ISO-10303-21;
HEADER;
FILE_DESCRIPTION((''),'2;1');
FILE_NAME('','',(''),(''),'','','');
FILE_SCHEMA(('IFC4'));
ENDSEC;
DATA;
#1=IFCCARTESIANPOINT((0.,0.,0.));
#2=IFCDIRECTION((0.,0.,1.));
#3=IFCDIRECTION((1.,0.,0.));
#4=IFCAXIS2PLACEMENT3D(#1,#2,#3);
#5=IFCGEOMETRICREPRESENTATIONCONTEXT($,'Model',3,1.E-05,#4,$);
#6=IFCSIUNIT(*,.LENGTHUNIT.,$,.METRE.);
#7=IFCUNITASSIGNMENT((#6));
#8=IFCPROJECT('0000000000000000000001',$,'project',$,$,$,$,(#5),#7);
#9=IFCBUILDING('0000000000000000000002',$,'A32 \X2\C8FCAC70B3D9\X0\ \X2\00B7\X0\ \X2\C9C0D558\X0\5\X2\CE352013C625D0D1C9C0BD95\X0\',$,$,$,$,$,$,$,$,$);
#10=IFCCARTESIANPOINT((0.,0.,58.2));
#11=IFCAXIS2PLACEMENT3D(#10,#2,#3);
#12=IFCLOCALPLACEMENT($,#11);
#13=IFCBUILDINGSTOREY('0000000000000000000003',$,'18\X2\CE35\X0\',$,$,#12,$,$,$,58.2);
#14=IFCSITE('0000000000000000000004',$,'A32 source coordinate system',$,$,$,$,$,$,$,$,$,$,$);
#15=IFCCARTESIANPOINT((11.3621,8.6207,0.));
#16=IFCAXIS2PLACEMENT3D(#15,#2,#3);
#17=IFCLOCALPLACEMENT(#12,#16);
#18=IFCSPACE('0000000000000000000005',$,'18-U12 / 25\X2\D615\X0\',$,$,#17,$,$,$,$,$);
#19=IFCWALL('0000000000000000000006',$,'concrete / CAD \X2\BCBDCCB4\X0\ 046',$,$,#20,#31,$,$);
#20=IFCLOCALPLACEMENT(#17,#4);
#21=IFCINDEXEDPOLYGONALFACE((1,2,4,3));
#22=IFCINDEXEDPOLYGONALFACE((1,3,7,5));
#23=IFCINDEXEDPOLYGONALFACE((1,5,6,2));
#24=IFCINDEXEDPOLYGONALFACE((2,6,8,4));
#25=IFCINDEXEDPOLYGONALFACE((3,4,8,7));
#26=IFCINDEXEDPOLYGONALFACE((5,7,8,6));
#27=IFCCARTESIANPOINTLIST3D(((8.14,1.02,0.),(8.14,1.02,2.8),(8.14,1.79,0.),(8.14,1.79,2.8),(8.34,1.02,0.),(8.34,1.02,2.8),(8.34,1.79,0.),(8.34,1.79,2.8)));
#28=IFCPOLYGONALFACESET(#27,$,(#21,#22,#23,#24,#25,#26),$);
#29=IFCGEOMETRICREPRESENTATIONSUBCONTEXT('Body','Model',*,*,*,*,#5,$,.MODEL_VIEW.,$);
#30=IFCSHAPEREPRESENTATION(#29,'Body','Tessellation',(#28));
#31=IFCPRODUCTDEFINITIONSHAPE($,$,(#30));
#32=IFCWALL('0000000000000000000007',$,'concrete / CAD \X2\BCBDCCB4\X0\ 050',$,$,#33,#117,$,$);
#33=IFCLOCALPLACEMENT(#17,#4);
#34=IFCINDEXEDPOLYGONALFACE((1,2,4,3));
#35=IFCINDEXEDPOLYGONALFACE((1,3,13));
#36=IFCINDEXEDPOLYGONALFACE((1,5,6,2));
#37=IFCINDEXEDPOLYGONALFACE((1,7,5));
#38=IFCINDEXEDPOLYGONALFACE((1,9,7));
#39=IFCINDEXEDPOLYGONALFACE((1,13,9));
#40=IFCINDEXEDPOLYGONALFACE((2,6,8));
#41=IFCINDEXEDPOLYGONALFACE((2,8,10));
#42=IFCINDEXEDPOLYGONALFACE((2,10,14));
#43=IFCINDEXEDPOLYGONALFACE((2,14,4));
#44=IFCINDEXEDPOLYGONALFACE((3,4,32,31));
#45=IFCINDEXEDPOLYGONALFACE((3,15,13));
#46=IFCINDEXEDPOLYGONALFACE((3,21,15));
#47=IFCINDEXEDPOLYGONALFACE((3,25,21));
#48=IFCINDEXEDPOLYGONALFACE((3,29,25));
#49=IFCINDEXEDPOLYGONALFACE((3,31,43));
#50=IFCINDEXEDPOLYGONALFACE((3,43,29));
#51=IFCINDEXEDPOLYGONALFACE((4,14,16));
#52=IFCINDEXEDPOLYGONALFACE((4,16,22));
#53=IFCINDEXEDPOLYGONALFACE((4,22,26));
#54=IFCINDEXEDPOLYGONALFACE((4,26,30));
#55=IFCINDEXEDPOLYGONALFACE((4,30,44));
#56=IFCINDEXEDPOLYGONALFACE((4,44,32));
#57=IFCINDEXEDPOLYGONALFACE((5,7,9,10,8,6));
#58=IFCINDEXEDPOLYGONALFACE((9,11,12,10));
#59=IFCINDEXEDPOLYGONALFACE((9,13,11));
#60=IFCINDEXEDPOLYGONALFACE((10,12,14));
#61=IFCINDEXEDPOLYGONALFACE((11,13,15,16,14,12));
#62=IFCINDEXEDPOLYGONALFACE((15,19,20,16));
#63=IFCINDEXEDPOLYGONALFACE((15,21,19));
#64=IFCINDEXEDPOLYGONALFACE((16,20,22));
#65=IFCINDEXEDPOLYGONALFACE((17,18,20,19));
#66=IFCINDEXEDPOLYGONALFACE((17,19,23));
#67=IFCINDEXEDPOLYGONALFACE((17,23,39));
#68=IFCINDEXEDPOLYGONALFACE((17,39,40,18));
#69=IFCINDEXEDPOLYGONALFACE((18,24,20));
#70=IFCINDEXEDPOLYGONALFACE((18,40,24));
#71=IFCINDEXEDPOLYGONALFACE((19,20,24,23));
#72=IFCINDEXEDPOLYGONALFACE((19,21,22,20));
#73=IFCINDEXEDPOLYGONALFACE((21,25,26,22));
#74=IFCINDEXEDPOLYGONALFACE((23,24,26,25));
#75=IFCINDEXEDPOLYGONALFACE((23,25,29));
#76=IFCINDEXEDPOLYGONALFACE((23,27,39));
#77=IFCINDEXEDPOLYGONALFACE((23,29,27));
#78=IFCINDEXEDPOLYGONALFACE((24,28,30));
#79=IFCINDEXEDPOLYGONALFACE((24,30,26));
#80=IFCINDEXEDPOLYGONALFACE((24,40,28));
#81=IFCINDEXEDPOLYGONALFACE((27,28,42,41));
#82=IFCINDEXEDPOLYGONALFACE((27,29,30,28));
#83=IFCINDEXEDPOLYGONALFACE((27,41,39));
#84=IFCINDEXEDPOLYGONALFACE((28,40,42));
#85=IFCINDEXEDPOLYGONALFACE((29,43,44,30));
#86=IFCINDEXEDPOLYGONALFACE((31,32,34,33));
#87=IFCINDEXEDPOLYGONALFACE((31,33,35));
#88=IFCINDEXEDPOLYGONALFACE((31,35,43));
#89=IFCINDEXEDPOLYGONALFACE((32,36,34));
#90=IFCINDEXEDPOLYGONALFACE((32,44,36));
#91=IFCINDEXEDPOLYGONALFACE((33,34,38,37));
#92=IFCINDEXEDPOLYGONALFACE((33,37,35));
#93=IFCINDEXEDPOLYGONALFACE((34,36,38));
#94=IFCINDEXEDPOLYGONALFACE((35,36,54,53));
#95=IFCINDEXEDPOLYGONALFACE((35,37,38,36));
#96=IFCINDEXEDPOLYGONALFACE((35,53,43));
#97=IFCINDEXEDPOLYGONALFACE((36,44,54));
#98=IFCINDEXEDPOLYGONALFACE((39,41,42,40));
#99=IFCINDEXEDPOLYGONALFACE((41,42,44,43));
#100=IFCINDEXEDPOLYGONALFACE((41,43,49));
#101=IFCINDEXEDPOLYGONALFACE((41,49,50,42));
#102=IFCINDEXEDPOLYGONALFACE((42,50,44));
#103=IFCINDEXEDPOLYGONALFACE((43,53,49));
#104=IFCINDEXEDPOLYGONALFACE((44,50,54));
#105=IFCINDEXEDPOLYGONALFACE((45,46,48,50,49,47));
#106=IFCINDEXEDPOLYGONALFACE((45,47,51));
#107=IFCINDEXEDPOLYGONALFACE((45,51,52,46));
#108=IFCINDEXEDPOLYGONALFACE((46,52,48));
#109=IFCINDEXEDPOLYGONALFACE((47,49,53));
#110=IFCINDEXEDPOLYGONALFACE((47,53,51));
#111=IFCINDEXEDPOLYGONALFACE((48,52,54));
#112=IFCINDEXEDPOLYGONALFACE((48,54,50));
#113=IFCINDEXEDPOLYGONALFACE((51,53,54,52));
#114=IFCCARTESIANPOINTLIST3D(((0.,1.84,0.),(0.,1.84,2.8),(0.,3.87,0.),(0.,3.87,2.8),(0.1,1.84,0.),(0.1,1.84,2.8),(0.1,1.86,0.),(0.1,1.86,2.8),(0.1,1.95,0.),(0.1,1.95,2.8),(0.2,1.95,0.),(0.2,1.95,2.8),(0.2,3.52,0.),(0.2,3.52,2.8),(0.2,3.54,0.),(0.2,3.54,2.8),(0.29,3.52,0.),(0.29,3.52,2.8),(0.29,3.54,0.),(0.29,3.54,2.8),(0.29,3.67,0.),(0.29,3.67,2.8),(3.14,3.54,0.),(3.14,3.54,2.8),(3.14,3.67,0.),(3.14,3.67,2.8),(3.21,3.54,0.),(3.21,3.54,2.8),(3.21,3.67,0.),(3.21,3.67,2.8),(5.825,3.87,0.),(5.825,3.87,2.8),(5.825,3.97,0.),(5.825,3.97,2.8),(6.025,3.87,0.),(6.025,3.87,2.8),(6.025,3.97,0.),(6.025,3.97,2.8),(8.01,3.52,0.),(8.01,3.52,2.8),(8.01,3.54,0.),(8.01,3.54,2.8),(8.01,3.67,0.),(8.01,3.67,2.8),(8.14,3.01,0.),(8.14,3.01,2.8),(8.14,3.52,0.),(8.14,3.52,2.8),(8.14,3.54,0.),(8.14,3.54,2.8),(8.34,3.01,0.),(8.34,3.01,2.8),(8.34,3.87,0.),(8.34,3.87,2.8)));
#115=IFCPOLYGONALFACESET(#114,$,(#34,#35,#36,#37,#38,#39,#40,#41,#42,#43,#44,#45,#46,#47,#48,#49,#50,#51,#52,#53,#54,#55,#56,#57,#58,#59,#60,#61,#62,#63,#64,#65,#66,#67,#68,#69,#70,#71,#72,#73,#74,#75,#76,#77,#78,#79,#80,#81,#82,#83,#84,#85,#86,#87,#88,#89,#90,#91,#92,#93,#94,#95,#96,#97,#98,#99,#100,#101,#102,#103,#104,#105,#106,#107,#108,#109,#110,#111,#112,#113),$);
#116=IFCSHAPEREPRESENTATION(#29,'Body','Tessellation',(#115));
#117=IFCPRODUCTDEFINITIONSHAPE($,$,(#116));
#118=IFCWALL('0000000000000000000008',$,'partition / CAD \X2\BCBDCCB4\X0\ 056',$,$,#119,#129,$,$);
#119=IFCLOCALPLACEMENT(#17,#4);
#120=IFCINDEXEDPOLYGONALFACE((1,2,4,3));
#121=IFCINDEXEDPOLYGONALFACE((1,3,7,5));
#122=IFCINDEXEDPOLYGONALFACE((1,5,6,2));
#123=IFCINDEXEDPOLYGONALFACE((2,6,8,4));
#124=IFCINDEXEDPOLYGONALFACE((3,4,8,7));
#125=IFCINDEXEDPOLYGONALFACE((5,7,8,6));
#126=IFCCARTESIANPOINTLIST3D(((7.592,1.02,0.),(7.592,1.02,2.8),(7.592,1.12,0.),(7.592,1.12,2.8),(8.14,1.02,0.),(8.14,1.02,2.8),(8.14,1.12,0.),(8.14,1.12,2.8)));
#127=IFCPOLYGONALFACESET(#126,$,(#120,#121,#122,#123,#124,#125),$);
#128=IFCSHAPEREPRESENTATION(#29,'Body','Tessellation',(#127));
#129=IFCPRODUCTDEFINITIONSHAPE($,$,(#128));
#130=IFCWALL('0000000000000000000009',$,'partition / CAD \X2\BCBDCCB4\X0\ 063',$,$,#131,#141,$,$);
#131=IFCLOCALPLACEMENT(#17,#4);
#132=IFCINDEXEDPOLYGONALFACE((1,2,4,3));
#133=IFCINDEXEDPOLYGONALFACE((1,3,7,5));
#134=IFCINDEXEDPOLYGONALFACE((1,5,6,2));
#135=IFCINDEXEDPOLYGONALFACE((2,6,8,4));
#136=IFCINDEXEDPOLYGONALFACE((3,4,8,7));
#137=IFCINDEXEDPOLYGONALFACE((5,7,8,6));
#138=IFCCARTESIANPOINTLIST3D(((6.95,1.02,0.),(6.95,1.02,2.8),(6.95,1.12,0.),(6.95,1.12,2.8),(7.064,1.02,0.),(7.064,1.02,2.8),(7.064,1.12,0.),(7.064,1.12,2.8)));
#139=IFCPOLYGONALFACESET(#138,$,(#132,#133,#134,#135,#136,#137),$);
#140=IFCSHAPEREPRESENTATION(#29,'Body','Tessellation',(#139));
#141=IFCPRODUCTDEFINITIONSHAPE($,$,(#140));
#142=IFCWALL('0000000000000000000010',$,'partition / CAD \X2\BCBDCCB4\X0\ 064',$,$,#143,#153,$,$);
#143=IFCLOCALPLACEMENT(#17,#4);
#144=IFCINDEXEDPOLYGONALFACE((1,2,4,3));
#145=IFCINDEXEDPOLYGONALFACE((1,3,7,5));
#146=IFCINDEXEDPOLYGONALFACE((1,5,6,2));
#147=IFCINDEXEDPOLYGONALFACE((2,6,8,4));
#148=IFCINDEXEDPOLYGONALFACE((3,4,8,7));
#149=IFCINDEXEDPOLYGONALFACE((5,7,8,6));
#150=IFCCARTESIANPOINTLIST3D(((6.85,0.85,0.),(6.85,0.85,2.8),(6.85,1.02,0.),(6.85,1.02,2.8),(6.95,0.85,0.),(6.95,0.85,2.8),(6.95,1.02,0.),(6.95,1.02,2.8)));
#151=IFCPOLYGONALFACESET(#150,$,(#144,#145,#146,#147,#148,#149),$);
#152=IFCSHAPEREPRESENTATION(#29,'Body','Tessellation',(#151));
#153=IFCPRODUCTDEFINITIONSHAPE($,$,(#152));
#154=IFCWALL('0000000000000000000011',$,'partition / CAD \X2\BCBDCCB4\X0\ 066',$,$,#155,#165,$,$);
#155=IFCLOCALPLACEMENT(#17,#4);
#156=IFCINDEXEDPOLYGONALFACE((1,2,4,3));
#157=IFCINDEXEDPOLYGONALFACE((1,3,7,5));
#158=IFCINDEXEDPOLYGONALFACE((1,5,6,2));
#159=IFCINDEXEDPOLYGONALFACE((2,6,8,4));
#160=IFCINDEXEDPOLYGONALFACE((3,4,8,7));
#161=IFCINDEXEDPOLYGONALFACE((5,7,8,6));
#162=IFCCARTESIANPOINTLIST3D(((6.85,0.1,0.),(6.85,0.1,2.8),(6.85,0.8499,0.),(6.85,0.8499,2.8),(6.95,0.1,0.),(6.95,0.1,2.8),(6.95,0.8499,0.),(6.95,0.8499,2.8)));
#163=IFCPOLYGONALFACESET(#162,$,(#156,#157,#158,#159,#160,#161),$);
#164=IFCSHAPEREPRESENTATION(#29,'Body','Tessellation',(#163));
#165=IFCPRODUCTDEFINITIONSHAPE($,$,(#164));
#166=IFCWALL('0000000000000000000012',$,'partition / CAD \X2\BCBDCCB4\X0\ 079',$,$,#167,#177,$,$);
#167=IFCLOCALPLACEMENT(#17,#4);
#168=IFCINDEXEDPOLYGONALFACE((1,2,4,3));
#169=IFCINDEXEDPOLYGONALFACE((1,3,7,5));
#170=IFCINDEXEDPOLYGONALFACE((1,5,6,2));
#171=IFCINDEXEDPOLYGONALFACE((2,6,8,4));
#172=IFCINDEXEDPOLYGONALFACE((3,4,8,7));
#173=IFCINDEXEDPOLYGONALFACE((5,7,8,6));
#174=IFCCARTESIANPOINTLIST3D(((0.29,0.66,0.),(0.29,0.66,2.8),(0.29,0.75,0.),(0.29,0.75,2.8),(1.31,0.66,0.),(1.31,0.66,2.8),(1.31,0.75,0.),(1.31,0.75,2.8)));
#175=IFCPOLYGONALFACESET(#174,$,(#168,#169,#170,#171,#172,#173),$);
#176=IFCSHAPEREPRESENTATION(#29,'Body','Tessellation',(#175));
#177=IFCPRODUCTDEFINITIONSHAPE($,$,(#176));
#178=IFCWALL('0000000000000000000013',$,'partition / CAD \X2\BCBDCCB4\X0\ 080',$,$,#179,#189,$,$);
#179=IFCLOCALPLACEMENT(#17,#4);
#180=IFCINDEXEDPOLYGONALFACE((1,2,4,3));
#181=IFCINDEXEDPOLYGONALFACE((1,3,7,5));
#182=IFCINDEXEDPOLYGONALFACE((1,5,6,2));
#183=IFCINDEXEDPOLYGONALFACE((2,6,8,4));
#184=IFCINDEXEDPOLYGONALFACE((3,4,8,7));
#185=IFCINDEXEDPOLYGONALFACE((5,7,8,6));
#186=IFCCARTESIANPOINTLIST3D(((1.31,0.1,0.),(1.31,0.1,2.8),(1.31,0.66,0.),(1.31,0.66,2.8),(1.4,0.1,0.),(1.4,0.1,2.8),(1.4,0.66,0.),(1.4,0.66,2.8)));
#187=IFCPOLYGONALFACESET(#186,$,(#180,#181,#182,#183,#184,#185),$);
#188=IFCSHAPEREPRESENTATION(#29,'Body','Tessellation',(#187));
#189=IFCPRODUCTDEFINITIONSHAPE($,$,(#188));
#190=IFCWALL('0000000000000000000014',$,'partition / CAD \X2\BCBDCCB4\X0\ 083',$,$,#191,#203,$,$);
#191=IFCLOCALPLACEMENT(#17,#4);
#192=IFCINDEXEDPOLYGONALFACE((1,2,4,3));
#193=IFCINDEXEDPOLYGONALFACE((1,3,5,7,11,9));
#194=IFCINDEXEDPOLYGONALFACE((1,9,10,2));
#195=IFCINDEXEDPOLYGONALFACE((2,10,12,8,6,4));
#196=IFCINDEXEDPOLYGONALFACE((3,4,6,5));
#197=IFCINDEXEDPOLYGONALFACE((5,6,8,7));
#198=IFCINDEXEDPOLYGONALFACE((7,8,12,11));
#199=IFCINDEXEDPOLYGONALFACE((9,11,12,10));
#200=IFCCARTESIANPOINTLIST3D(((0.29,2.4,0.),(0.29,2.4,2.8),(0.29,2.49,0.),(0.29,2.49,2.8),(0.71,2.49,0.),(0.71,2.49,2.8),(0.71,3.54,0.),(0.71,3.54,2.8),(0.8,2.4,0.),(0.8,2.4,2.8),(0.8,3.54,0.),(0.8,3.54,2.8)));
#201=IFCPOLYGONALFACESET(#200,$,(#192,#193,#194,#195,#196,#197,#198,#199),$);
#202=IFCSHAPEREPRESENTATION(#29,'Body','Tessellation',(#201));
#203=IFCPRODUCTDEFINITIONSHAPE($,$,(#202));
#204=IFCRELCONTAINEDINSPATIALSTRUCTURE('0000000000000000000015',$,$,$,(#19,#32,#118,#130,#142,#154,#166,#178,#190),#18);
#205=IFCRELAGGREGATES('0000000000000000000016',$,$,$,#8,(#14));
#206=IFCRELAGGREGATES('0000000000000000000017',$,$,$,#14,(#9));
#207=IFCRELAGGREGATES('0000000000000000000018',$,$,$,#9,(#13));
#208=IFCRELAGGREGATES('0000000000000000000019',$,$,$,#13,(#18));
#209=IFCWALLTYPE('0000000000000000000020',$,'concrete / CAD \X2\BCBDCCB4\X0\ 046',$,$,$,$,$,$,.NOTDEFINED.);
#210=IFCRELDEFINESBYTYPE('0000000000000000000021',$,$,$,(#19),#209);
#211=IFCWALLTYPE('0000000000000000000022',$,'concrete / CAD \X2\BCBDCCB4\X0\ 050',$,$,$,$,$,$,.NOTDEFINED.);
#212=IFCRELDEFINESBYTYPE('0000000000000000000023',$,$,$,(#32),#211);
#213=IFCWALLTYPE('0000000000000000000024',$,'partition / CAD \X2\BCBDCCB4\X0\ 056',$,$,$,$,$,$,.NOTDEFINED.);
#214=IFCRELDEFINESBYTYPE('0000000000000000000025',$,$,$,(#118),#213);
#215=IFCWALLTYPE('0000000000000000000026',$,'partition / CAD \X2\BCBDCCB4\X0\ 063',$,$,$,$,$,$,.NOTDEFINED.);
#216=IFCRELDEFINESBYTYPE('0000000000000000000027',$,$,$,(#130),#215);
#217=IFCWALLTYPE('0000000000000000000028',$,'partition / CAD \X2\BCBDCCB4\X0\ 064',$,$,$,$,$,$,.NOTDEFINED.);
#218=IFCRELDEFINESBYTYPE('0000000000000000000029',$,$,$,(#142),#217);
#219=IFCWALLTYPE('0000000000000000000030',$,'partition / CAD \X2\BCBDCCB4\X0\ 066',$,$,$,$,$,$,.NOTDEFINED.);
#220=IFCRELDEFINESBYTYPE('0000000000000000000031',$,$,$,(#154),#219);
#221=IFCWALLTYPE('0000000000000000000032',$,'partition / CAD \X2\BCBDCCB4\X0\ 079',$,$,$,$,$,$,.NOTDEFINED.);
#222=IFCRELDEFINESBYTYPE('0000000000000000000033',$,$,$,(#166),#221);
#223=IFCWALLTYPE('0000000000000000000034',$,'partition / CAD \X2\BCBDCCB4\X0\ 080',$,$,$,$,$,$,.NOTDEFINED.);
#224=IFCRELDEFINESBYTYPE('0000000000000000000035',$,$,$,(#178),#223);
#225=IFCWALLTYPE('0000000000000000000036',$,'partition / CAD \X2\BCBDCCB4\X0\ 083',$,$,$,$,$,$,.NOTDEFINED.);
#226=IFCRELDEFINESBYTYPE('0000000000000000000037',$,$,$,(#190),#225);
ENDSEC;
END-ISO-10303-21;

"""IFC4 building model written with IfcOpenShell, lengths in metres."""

from ifc_helpers import new_model, si_unit, frame, origin, origin_with_axes, place, context, subcontext, project, spatial, polyline, outline, extrude, source, transform, mapped, type_object, type_shapes, element, save


model = new_model("IFC4")

# Units and contexts
model_context = context("Model", 3, precision=1e-05, world=origin_with_axes())
body_context = subcontext(model_context, "Body", "Model", "MODEL_VIEW")
ifc_project = project(units=[si_unit("LENGTHUNIT", "METRE")], contexts=[model_context])

# Site, building, storey, space
site = spatial("IfcSite", under=ifc_project, Name="A32 source coordinate system")
building = spatial("IfcBuilding", under=site, Name="A32 주거동 · 지하5층–옥탑지붕")
storey_placement = place(None, frame((0.0, 0.0, 58.2), z_axis=(0.0, 0.0, 1.0), x_axis=(1.0, 0.0, 0.0)))
storey = spatial("IfcBuildingStorey", under=building, at=storey_placement, Name="18층", Elevation=58.2)
space_1_placement = place(storey_placement, frame((11.3621, 8.6207, 0.0), z_axis=(0.0, 0.0, 1.0), x_axis=(1.0, 0.0, 0.0)))
space_1 = spatial("IfcSpace", under=storey, at=space_1_placement, Name="18-U12 / 25형")

# Walls
wall_type_1 = type_object("IfcWallType", Name="concrete / CAD 벽체 046", PredefinedType="NOTDEFINED")
shared_shape_1 = source(origin(), body_context, "Body", "SweptSolid", [
    extrude(outline(polyline([(8.14, 1.02), (8.14, 1.79), (8.34, 1.79), (8.34, 1.02), (8.14, 1.02)])), origin(), (0.0, 0.0, 1.0), 2.8),
])
type_shapes(wall_type_1, [shared_shape_1])
wall_1_placement = place(space_1_placement, origin_with_axes())
element("IfcWall", 1, at=wall_1_placement, inside=space_1, type_object=wall_type_1, Name="concrete / CAD 벽체 046", context=body_context, shape_type="MappedRepresentation", body=[
    mapped(shared_shape_1, transform((0.0, 0.0, 0.0), scale=1.0)),
])
wall_type_2 = type_object("IfcWallType", Name="concrete / CAD 벽체 050", PredefinedType="NOTDEFINED")
shared_shape_2 = source(origin(), body_context, "Body", "SweptSolid", [
    extrude(outline(polyline([(8.01, 3.52), (0.29, 3.52), (0.29, 3.54), (0.2, 3.54), (0.2, 3.52), (0.2, 1.95), (0.1, 1.95), (0.1, 1.86), (0.1, 1.84), (0.0, 1.84), (0.0, 3.87), (5.825, 3.87), (5.825, 3.97), (6.025, 3.97), (6.025, 3.87), (8.34, 3.87), (8.34, 3.01), (8.14, 3.01), (8.14, 3.52), (8.14, 3.54), (8.01, 3.54), (8.01, 3.52)]), holes=[polyline([(3.14, 3.54), (3.14, 3.67), (0.29, 3.67), (0.29, 3.54), (3.14, 3.54)]), polyline([(8.01, 3.67), (3.21, 3.67), (3.21, 3.54), (8.01, 3.54), (8.01, 3.67)])]), origin(), (0.0, 0.0, 1.0), 2.8),
])
type_shapes(wall_type_2, [shared_shape_2])
wall_2_placement = place(space_1_placement, origin_with_axes())
element("IfcWall", 2, at=wall_2_placement, inside=space_1, type_object=wall_type_2, Name="concrete / CAD 벽체 050", context=body_context, shape_type="MappedRepresentation", body=[
    mapped(shared_shape_2, transform((0.0, 0.0, 0.0), scale=1.0)),
])
wall_type_3 = type_object("IfcWallType", Name="partition / CAD 벽체 056", PredefinedType="NOTDEFINED")
shared_shape_3 = source(origin(), body_context, "Body", "SweptSolid", [
    extrude(outline(polyline([(7.592, 1.12), (8.14, 1.12), (8.14, 1.02), (7.592, 1.02), (7.592, 1.12)])), origin(), (0.0, 0.0, 1.0), 2.8),
])
type_shapes(wall_type_3, [shared_shape_3])
wall_3_placement = place(space_1_placement, origin_with_axes())
element("IfcWall", 3, at=wall_3_placement, inside=space_1, type_object=wall_type_3, Name="partition / CAD 벽체 056", context=body_context, shape_type="MappedRepresentation", body=[
    mapped(shared_shape_3, transform((0.0, 0.0, 0.0), scale=1.0)),
])
wall_type_4 = type_object("IfcWallType", Name="partition / CAD 벽체 063", PredefinedType="NOTDEFINED")
shared_shape_4 = source(origin(), body_context, "Body", "SweptSolid", [
    extrude(outline(polyline([(6.95, 1.12), (7.064, 1.12), (7.064, 1.02), (6.95, 1.02), (6.95, 1.12)])), origin(), (0.0, 0.0, 1.0), 2.8),
])
type_shapes(wall_type_4, [shared_shape_4])
wall_4_placement = place(space_1_placement, origin_with_axes())
element("IfcWall", 4, at=wall_4_placement, inside=space_1, type_object=wall_type_4, Name="partition / CAD 벽체 063", context=body_context, shape_type="MappedRepresentation", body=[
    mapped(shared_shape_4, transform((0.0, 0.0, 0.0), scale=1.0)),
])
wall_type_5 = type_object("IfcWallType", Name="partition / CAD 벽체 064", PredefinedType="NOTDEFINED")
shared_shape_5 = source(origin(), body_context, "Body", "SweptSolid", [
    extrude(outline(polyline([(6.95, 0.85), (6.85, 0.85), (6.85, 1.02), (6.95, 1.02), (6.95, 0.85)])), origin(), (0.0, 0.0, 1.0), 2.8),
])
type_shapes(wall_type_5, [shared_shape_5])
wall_5_placement = place(space_1_placement, origin_with_axes())
element("IfcWall", 5, at=wall_5_placement, inside=space_1, type_object=wall_type_5, Name="partition / CAD 벽체 064", context=body_context, shape_type="MappedRepresentation", body=[
    mapped(shared_shape_5, transform((0.0, 0.0, 0.0), scale=1.0)),
])
wall_type_6 = type_object("IfcWallType", Name="partition / CAD 벽체 066", PredefinedType="NOTDEFINED")
shared_shape_6 = source(origin(), body_context, "Body", "SweptSolid", [
    extrude(outline(polyline([(6.85, 0.8499), (6.95, 0.8499), (6.95, 0.1), (6.85, 0.1), (6.85, 0.8499)])), origin(), (0.0, 0.0, 1.0), 2.8),
])
type_shapes(wall_type_6, [shared_shape_6])
wall_6_placement = place(space_1_placement, origin_with_axes())
element("IfcWall", 6, at=wall_6_placement, inside=space_1, type_object=wall_type_6, Name="partition / CAD 벽체 066", context=body_context, shape_type="MappedRepresentation", body=[
    mapped(shared_shape_6, transform((0.0, 0.0, 0.0), scale=1.0)),
])
wall_type_7 = type_object("IfcWallType", Name="partition / CAD 벽체 079", PredefinedType="NOTDEFINED")
shared_shape_7 = source(origin(), body_context, "Body", "SweptSolid", [
    extrude(outline(polyline([(0.29, 0.75), (1.31, 0.75), (1.31, 0.66), (0.29, 0.66), (0.29, 0.75)])), origin(), (0.0, 0.0, 1.0), 2.8),
])
type_shapes(wall_type_7, [shared_shape_7])
wall_7_placement = place(space_1_placement, origin_with_axes())
element("IfcWall", 7, at=wall_7_placement, inside=space_1, type_object=wall_type_7, Name="partition / CAD 벽체 079", context=body_context, shape_type="MappedRepresentation", body=[
    mapped(shared_shape_7, transform((0.0, 0.0, 0.0), scale=1.0)),
])
wall_type_8 = type_object("IfcWallType", Name="partition / CAD 벽체 080", PredefinedType="NOTDEFINED")
shared_shape_8 = source(origin(), body_context, "Body", "SweptSolid", [
    extrude(outline(polyline([(1.4, 0.66), (1.4, 0.1), (1.31, 0.1), (1.31, 0.66), (1.4, 0.66)])), origin(), (0.0, 0.0, 1.0), 2.8),
])
type_shapes(wall_type_8, [shared_shape_8])
wall_8_placement = place(space_1_placement, origin_with_axes())
element("IfcWall", 8, at=wall_8_placement, inside=space_1, type_object=wall_type_8, Name="partition / CAD 벽체 080", context=body_context, shape_type="MappedRepresentation", body=[
    mapped(shared_shape_8, transform((0.0, 0.0, 0.0), scale=1.0)),
])
wall_type_9 = type_object("IfcWallType", Name="partition / CAD 벽체 083", PredefinedType="NOTDEFINED")
shared_shape_9 = source(origin(), body_context, "Body", "SweptSolid", [
    extrude(outline(polyline([(0.71, 2.49), (0.71, 3.54), (0.8, 3.54), (0.8, 2.4), (0.29, 2.4), (0.29, 2.49), (0.71, 2.49)])), origin(), (0.0, 0.0, 1.0), 2.8),
])
type_shapes(wall_type_9, [shared_shape_9])
wall_9_placement = place(space_1_placement, origin_with_axes())
element("IfcWall", 9, at=wall_9_placement, inside=space_1, type_object=wall_type_9, Name="partition / CAD 벽체 083", context=body_context, shape_type="MappedRepresentation", body=[
    mapped(shared_shape_9, transform((0.0, 0.0, 0.0), scale=1.0)),
])

save(model, "model.ifc")
